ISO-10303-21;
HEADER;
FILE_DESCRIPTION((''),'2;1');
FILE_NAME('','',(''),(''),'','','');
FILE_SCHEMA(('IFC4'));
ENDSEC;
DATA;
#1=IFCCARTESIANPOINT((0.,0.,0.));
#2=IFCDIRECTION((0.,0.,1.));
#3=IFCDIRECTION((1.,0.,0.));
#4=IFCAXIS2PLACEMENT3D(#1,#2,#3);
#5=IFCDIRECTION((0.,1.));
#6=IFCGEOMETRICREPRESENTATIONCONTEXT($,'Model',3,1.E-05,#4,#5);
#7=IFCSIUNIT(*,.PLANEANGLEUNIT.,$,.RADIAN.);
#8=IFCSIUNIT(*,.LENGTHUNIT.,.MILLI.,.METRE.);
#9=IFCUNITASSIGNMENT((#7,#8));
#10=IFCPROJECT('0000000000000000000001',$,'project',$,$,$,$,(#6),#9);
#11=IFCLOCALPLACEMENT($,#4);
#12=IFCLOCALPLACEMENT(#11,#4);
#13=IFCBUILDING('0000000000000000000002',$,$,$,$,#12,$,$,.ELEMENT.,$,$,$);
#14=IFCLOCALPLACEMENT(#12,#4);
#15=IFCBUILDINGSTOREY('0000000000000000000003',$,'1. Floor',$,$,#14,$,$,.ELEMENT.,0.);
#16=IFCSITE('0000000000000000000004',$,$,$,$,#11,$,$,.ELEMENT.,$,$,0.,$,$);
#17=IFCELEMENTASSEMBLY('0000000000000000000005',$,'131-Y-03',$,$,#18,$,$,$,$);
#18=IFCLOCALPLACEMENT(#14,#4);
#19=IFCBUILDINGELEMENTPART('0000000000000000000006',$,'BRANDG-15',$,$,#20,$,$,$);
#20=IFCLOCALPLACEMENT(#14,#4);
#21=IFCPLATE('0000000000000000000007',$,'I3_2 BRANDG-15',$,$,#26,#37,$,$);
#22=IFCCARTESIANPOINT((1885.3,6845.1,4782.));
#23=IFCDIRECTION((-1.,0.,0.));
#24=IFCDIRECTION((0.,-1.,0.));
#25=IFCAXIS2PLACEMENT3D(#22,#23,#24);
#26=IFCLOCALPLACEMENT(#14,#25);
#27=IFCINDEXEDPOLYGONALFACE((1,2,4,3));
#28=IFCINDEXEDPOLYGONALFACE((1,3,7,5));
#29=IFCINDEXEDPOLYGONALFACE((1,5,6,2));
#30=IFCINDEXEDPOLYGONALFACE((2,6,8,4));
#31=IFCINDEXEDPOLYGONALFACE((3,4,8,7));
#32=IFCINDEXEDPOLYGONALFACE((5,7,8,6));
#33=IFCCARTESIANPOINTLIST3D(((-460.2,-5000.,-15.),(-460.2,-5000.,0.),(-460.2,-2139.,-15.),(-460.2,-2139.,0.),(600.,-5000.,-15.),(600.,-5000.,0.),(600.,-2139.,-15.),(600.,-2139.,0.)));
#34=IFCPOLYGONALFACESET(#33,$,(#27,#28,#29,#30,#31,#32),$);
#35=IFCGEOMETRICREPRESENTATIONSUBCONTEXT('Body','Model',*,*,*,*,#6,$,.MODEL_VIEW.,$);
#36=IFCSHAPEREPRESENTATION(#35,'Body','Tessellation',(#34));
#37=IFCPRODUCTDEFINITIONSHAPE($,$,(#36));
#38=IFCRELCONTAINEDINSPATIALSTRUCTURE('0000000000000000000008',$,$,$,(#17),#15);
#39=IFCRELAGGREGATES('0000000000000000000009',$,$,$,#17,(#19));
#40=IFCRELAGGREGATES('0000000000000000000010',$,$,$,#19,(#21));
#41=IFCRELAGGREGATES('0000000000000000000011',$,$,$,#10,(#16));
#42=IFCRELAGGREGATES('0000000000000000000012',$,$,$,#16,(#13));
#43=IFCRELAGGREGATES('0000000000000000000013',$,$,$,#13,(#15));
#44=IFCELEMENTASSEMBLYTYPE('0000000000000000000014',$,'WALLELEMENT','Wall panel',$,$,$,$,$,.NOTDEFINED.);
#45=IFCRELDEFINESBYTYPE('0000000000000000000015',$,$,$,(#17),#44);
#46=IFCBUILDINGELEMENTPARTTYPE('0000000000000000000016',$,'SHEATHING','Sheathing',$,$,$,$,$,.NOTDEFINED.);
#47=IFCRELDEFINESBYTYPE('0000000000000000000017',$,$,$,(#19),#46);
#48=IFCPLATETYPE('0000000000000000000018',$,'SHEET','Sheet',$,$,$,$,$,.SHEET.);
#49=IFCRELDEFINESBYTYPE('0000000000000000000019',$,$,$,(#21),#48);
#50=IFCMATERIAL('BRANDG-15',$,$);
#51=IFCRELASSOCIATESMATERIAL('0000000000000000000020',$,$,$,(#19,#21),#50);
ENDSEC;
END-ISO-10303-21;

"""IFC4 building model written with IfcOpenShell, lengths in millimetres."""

from ifc_helpers import new_model, si_unit, direction, frame, origin_with_axes, origin_2d_with_axis, place, context, subcontext, project, spatial, rectangle, extrude, material, type_object, element, aggregate, save


model = new_model("IFC4")

# Units and contexts
model_context = context("Model", 3, precision=1e-05, world=origin_with_axes(), true_north=direction((0.0, 1.0)))
body_context = subcontext(model_context, "Body", "Model", "MODEL_VIEW")
ifc_project = project(units=[si_unit("PLANEANGLEUNIT", "RADIAN"), si_unit("LENGTHUNIT", "METRE", prefix="MILLI")], contexts=[model_context])

# Site, building, storey
site_placement = place(None, origin_with_axes())
site = spatial("IfcSite", under=ifc_project, at=site_placement, CompositionType="ELEMENT", RefElevation=0.0)
building_placement = place(site_placement, origin_with_axes())
building = spatial("IfcBuilding", under=site, at=building_placement, CompositionType="ELEMENT")
storey_placement = place(building_placement, origin_with_axes())
storey = spatial("IfcBuildingStorey", under=building, at=storey_placement, Name="1. Floor", CompositionType="ELEMENT", Elevation=0.0)

# Element assembly
element_assembly_type_1 = type_object("IfcElementAssemblyType", Name="WALLELEMENT", Description="Wall panel", PredefinedType="NOTDEFINED")
assembly_1_placement = place(storey_placement, origin_with_axes())
assembly_1 = element("IfcElementAssembly", 1, at=assembly_1_placement, inside=storey, type_object=element_assembly_type_1, Name="131-Y-03")

# Shared definitions
ifc_material_1 = material(Name="BRANDG-15")
building_element_part_type_1 = type_object("IfcBuildingElementPartType", Name="SHEATHING", Description="Sheathing", PredefinedType="NOTDEFINED")
plate_type_1 = type_object("IfcPlateType", Name="SHEET", Description="Sheet", PredefinedType="SHEET")

# Building element part
building_element_part_1_placement = place(storey_placement, origin_with_axes())
building_element_part_1 = element("IfcBuildingElementPart", 2, at=building_element_part_1_placement, type_object=building_element_part_type_1, material=ifc_material_1, Name="BRANDG-15")
aggregate(assembly_1, [building_element_part_1])

# Plate
plate_1_placement = place(storey_placement, frame((1885.3, 6845.1, 4782.0), z_axis=(-1.0, 0.0, 0.0), x_axis=(0.0, -1.0, 0.0)))
plate_1 = element("IfcPlate", 3, at=plate_1_placement, type_object=plate_type_1, material=ifc_material_1, Name="I3_2 BRANDG-15", context=body_context, shape_type="SweptSolid", body=[
    extrude(rectangle(XDim=15.0, YDim=1060.2, at=origin_2d_with_axis()), frame((69.9, -5000.0, -7.5), z_axis=(0.0, 1.0, 0.0), x_axis=(0.0, 0.0, 1.0)), (0.0, 0.0, 1.0), 2861.0),
])
aggregate(building_element_part_1, [plate_1])

save(model, "model.ifc")
